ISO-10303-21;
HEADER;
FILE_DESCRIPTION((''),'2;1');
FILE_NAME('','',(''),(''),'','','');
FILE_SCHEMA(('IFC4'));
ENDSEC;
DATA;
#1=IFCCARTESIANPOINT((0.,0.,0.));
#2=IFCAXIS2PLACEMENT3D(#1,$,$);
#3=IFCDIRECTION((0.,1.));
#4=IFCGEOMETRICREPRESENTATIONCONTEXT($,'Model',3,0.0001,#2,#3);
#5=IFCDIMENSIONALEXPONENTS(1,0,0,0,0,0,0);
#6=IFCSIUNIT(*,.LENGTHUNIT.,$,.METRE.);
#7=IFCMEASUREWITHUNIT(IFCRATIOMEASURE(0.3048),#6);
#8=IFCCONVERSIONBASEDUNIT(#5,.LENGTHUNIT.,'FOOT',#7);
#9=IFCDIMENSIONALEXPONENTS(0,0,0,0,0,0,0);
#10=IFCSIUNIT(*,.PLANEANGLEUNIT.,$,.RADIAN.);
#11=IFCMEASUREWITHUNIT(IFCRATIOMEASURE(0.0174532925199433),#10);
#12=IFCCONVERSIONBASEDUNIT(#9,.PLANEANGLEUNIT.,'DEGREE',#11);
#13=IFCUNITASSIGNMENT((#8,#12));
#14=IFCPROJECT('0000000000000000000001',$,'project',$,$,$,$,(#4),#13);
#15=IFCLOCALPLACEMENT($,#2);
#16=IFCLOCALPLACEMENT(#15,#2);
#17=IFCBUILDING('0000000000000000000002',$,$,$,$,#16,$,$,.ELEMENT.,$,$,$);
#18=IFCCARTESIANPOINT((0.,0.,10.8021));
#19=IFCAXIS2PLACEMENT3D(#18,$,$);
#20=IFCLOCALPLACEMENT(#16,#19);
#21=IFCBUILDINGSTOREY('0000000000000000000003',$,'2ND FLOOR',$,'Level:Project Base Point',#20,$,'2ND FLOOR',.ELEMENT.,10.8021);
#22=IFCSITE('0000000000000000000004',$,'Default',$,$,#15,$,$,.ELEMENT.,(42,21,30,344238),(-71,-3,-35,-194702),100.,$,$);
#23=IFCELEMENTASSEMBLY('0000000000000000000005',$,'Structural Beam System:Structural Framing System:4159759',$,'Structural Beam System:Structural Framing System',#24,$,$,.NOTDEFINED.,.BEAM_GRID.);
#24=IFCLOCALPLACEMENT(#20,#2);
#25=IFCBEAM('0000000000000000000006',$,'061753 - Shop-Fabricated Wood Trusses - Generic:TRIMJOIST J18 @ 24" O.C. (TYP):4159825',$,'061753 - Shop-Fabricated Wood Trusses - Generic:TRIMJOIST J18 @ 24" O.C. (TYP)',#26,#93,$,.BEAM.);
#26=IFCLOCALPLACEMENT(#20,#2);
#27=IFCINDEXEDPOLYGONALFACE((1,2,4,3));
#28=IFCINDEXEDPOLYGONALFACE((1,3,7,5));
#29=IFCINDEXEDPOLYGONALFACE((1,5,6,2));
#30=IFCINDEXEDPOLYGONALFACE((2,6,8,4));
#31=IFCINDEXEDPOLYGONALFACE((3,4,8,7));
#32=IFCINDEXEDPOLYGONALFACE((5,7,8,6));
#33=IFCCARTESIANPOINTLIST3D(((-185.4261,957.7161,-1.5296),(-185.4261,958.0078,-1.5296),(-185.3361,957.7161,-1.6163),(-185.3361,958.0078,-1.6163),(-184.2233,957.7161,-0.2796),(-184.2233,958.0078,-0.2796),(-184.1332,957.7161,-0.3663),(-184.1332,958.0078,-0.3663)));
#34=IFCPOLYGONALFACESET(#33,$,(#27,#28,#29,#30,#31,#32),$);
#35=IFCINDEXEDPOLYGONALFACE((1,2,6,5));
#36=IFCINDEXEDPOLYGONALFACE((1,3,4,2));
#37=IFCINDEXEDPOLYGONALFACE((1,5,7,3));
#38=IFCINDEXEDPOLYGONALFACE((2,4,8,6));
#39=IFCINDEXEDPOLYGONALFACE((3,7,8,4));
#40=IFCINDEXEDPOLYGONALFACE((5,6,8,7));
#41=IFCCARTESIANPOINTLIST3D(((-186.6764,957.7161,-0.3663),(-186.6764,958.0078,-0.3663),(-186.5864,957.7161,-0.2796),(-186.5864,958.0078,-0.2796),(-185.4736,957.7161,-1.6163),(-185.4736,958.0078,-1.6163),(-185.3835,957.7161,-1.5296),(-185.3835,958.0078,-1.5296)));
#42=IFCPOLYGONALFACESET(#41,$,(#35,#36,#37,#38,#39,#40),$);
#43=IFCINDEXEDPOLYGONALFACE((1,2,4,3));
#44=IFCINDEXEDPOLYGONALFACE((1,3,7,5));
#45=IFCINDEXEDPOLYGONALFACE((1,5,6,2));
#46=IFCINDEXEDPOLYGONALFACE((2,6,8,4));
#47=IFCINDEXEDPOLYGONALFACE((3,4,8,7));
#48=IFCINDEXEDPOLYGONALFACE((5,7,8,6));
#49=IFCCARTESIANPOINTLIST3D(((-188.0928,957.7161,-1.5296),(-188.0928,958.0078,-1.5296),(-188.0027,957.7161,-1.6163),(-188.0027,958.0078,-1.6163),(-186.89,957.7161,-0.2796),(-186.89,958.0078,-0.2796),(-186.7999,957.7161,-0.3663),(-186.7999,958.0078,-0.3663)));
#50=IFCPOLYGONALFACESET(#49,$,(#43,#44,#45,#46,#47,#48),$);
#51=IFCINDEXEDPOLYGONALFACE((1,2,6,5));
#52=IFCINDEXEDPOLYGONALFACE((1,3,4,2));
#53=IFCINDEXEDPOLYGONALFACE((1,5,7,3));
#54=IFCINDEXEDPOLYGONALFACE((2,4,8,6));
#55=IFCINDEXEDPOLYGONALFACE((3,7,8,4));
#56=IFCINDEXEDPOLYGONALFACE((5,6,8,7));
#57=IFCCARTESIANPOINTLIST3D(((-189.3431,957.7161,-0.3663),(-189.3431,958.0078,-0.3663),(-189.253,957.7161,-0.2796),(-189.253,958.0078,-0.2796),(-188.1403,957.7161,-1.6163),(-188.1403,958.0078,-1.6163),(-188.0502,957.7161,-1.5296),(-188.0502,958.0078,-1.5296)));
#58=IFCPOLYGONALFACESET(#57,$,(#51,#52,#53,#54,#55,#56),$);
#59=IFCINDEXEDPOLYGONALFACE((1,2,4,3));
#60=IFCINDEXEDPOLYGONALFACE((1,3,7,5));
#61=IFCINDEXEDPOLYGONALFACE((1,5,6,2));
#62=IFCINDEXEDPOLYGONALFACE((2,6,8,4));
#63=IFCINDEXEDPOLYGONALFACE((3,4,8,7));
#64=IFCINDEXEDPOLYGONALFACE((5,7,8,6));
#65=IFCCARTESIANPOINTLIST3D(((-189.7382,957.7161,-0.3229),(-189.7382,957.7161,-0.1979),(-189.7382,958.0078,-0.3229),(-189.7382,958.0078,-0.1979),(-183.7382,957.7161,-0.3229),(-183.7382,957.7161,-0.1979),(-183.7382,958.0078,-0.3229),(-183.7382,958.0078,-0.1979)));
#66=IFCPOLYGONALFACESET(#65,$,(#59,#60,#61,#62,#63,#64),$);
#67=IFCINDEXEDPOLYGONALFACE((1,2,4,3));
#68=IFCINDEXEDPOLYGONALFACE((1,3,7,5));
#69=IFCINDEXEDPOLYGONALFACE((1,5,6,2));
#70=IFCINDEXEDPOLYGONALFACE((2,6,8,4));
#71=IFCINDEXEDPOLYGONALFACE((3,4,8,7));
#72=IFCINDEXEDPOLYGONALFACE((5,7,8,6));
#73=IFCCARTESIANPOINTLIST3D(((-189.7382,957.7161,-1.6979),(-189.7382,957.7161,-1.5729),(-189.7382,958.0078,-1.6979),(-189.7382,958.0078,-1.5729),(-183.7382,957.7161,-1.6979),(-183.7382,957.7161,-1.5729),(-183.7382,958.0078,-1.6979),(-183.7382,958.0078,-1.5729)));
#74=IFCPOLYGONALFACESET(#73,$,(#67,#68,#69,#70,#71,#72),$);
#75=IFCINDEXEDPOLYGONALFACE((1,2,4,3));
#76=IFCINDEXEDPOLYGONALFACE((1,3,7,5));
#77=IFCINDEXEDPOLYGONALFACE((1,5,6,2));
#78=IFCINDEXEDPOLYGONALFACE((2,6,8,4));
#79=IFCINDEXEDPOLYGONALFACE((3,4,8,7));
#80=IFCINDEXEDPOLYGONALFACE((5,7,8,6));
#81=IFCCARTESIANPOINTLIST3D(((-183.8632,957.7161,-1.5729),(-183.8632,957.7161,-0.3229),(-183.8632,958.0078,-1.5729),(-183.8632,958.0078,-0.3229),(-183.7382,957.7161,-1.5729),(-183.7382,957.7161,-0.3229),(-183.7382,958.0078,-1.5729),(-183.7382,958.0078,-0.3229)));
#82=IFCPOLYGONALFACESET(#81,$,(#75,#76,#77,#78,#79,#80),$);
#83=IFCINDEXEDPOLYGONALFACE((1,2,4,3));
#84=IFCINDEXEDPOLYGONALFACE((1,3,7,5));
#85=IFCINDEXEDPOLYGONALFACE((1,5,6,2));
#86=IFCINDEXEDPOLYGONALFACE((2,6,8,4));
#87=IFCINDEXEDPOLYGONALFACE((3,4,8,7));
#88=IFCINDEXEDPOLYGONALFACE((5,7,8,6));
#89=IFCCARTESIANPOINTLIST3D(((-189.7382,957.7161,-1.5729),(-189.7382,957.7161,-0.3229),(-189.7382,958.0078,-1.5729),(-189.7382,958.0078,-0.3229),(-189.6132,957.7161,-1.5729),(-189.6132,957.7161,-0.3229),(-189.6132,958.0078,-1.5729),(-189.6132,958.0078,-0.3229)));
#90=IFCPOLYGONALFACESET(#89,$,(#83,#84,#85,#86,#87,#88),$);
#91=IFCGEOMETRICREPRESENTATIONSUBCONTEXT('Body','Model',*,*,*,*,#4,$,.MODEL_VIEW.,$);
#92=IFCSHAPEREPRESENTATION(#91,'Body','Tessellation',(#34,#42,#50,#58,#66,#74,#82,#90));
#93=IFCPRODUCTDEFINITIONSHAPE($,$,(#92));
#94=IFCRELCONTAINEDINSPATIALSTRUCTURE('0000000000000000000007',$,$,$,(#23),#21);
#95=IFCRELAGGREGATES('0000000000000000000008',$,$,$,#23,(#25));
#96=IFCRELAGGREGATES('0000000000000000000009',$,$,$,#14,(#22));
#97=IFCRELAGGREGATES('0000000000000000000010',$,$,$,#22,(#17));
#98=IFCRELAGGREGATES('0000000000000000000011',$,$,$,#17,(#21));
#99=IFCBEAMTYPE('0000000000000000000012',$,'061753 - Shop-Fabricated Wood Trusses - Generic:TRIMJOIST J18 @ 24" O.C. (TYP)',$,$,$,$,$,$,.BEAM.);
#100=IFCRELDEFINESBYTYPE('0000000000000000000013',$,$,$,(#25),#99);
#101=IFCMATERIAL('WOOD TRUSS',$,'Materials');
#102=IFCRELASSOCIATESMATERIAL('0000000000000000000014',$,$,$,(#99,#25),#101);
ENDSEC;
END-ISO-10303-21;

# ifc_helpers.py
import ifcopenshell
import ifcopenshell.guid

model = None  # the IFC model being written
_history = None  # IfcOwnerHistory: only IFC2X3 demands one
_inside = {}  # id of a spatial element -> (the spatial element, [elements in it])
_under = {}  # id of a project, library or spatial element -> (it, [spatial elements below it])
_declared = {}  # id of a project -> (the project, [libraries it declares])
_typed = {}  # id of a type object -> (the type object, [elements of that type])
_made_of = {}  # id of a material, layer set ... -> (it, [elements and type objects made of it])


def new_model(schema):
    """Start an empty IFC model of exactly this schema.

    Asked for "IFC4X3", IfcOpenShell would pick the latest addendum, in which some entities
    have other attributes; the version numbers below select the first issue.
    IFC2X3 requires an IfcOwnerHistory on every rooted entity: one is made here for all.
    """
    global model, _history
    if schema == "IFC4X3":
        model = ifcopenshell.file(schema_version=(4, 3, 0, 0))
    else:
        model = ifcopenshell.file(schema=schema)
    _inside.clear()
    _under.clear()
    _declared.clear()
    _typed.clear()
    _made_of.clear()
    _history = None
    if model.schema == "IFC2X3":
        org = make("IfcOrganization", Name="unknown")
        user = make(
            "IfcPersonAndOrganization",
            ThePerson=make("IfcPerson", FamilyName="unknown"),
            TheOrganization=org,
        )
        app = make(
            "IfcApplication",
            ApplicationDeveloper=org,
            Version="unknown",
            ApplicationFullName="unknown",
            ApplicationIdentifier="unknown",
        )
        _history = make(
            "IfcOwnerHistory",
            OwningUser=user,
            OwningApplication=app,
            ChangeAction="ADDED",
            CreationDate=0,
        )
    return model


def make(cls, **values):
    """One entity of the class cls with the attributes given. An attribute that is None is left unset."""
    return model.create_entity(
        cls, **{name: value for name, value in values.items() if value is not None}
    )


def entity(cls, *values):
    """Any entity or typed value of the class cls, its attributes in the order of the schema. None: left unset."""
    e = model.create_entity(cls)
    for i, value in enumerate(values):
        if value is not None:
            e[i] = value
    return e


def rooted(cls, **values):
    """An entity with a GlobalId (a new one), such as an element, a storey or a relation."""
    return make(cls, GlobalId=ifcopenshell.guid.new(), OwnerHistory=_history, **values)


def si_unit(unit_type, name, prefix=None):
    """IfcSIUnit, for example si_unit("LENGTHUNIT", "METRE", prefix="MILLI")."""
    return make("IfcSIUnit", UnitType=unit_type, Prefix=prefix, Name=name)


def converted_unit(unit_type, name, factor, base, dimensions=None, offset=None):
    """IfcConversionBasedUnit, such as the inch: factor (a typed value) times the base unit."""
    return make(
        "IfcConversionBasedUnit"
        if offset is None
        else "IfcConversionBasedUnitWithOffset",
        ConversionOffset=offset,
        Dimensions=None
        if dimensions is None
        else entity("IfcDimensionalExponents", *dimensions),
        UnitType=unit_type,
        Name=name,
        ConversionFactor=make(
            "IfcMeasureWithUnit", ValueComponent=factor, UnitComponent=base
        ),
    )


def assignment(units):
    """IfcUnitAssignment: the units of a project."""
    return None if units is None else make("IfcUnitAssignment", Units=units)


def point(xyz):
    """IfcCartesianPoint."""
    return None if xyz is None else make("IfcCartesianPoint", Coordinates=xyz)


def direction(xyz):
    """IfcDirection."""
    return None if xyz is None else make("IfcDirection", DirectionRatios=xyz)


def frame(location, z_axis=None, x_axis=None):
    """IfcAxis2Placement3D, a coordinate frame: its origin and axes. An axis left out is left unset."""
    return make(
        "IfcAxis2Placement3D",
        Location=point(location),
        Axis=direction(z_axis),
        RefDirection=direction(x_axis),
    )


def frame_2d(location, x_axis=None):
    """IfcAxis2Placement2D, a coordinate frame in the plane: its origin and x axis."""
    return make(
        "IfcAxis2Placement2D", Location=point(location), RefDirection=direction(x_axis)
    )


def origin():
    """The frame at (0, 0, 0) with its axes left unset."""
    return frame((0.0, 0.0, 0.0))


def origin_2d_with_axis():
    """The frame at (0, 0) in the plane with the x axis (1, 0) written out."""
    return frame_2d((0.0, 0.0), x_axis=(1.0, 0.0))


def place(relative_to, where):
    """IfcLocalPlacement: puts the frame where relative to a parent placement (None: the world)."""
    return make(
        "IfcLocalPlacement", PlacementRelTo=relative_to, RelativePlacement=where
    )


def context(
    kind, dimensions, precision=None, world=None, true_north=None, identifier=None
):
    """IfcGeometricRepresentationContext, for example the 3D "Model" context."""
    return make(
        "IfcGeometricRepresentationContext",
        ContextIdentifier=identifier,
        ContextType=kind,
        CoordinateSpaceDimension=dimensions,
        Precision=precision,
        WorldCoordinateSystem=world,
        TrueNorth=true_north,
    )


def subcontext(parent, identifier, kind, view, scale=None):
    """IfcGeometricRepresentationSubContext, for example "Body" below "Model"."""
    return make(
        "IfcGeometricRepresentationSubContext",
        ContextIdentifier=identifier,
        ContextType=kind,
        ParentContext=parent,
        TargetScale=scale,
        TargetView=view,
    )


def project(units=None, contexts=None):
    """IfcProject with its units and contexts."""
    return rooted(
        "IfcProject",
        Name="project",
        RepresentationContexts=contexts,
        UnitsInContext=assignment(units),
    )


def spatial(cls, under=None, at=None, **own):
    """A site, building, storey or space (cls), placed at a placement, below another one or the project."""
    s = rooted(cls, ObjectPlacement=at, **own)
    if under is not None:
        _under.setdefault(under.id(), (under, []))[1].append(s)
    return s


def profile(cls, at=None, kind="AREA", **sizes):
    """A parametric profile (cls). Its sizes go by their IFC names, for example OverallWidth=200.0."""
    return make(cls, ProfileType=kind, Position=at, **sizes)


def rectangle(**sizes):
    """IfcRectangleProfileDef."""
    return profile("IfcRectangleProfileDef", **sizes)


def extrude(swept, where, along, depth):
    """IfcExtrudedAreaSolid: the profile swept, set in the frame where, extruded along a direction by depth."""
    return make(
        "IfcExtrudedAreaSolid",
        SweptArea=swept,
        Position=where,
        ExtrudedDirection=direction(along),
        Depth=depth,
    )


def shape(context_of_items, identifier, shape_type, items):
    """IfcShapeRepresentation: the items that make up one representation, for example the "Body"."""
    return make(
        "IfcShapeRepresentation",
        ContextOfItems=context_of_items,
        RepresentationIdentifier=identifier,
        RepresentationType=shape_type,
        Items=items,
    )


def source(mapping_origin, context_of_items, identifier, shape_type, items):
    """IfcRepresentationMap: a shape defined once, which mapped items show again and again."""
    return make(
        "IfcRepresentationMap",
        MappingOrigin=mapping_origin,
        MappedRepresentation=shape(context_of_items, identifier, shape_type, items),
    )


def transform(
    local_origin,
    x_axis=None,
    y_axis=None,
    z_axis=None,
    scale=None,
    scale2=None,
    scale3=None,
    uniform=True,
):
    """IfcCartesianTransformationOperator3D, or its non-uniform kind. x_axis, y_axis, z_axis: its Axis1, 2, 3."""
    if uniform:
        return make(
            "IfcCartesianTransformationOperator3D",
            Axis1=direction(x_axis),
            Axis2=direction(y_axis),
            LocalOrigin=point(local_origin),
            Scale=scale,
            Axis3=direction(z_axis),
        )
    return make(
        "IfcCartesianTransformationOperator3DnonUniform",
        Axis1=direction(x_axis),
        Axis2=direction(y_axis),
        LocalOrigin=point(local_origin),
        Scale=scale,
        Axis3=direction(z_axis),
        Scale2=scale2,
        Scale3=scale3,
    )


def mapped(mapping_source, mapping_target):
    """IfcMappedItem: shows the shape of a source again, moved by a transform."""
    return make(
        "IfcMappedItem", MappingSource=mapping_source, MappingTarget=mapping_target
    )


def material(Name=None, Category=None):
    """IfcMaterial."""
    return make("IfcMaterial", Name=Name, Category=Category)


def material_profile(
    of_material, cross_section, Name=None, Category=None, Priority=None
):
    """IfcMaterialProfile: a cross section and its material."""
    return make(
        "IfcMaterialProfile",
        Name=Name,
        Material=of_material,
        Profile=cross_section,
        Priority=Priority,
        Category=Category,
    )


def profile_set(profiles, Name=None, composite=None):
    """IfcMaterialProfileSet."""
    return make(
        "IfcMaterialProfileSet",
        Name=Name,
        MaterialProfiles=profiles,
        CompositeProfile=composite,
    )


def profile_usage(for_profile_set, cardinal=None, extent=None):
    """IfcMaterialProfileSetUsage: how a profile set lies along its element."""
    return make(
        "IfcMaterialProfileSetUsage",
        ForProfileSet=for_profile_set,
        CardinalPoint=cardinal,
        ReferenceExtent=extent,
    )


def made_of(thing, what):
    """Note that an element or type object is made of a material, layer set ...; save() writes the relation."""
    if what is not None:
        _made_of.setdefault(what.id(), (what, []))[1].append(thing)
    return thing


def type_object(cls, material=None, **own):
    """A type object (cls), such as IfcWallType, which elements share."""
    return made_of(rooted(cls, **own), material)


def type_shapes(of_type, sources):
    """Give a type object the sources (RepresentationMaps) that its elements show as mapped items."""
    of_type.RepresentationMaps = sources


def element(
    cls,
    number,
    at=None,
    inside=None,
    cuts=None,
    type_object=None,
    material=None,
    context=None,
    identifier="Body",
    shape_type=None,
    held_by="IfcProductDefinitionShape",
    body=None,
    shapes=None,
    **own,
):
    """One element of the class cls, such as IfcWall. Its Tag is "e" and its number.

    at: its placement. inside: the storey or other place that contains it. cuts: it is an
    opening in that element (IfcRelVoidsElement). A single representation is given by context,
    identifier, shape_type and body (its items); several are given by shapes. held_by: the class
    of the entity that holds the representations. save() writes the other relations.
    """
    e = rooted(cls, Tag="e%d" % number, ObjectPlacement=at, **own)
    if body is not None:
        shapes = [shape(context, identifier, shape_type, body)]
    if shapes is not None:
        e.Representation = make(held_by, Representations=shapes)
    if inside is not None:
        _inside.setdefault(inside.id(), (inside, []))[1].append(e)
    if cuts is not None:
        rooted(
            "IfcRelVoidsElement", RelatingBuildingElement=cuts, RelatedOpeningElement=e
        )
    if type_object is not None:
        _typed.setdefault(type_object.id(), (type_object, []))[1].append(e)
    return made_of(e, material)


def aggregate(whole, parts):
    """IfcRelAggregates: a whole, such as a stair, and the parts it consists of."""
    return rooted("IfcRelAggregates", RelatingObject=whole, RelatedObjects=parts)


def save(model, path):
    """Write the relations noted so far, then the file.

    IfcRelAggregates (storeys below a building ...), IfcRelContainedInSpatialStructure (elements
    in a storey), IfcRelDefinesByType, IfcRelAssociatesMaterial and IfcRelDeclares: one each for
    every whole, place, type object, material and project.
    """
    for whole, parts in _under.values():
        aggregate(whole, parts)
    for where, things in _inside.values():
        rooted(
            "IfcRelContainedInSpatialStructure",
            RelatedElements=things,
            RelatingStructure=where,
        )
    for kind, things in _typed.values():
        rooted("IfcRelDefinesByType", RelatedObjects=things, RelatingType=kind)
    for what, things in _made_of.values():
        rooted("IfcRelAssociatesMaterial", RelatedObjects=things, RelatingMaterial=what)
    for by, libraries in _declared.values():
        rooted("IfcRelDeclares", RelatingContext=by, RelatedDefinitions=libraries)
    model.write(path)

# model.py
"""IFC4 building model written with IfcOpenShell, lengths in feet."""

from ifc_helpers import new_model, entity, si_unit, converted_unit, direction, frame, frame_2d, origin, origin_2d_with_axis, place, context, subcontext, project, spatial, rectangle, extrude, source, transform, mapped, material, material_profile, profile_set, profile_usage, type_object, type_shapes, element, aggregate, save


model = new_model("IFC4")

# Units and contexts
model_context = context("Model", 3, precision=0.0001, world=origin(), true_north=direction((0.0, 1.0)))
body_context = subcontext(model_context, "Body", "Model", "MODEL_VIEW")
ifc_project = project(units=[converted_unit("LENGTHUNIT", "FOOT", entity("IfcRatioMeasure", 0.3048), si_unit("LENGTHUNIT", "METRE"), dimensions=[1, 0, 0, 0, 0, 0, 0]), converted_unit("PLANEANGLEUNIT", "DEGREE", entity("IfcRatioMeasure", 0.0174532925199433), si_unit("PLANEANGLEUNIT", "RADIAN"), dimensions=[0, 0, 0, 0, 0, 0, 0])], contexts=[model_context])

# Site, building, storey
site_placement = place(None, origin())
site = spatial("IfcSite", under=ifc_project, at=site_placement, Name="Default", CompositionType="ELEMENT", RefLatitude=(42, 21, 30, 344238), RefLongitude=(-71, -3, -35, -194702), RefElevation=100.0)
building_placement = place(site_placement, origin())
building = spatial("IfcBuilding", under=site, at=building_placement, CompositionType="ELEMENT")
storey_placement = place(building_placement, frame((0.0, 0.0, 10.8021)))
storey = spatial("IfcBuildingStorey", under=building, at=storey_placement, Name="2ND FLOOR", ObjectType="Level:Project Base Point", LongName="2ND FLOOR", CompositionType="ELEMENT", Elevation=10.8021)

# Element assembly
ifc_material_1 = material(Name="WOOD TRUSS", Category="Materials")
ifc_material_profile_1 = material_profile(ifc_material_1, rectangle(XDim=1.7347, YDim=0.125, at=frame_2d((0.0, 0.0), x_axis=(1.0, 0.0))), Name="TRIMJOIST J18 @ 24\" O.C. (TYP)")
ifc_material_profile_2 = material_profile(ifc_material_1, rectangle(XDim=1.7347, YDim=0.125, at=frame_2d((0.0, 0.0), x_axis=(1.0, 0.0))), Name="TRIMJOIST J18 @ 24\" O.C. (TYP)")
ifc_material_profile_3 = material_profile(ifc_material_1, rectangle(XDim=1.7347, YDim=0.125, at=frame_2d((0.0, 0.0), x_axis=(1.0, 0.0))), Name="TRIMJOIST J18 @ 24\" O.C. (TYP)")
ifc_material_profile_4 = material_profile(ifc_material_1, rectangle(XDim=1.7347, YDim=0.125, at=frame_2d((0.0, 0.0), x_axis=(1.0, 0.0))), Name="TRIMJOIST J18 @ 24\" O.C. (TYP)")
ifc_material_profile_5 = material_profile(ifc_material_1, rectangle(XDim=1.7347, YDim=0.125, at=frame_2d((0.0, 0.0), x_axis=(1.0, 0.0))), Name="TRIMJOIST J18 @ 24\" O.C. (TYP)")
ifc_material_profile_6 = material_profile(ifc_material_1, rectangle(XDim=1.7347, YDim=0.125, at=frame_2d((0.0, 0.0), x_axis=(1.0, 0.0))), Name="TRIMJOIST J18 @ 24\" O.C. (TYP)")
ifc_material_profile_7 = material_profile(ifc_material_1, rectangle(XDim=1.7347, YDim=0.125, at=frame_2d((0.0, 0.0), x_axis=(1.0, 0.0))), Name="TRIMJOIST J18 @ 24\" O.C. (TYP)")
ifc_material_profile_8 = material_profile(ifc_material_1, rectangle(XDim=1.7347, YDim=0.125, at=frame_2d((0.0, 0.0), x_axis=(1.0, 0.0))), Name="TRIMJOIST J18 @ 24\" O.C. (TYP)")
ifc_material_profile_9 = material_profile(ifc_material_1, rectangle(XDim=1.7347, YDim=0.125, at=frame_2d((0.0, 0.0), x_axis=(1.0, 0.0))), Name="TRIMJOIST J18 @ 24\" O.C. (TYP)")
ifc_material_profile_10 = material_profile(ifc_material_1, rectangle(XDim=1.7347, YDim=0.125, at=origin_2d_with_axis()), Name="TRIMJOIST J18 @ 24\" O.C. (TYP)")
ifc_material_profile_11 = material_profile(ifc_material_1, rectangle(XDim=0.125, YDim=0.2917, at=origin_2d_with_axis()), Name="TRIMJOIST J18 @ 24\" O.C. (TYP)")
ifc_material_profile_12 = material_profile(ifc_material_1, rectangle(XDim=0.125, YDim=0.2917, at=origin_2d_with_axis()), Name="TRIMJOIST J18 @ 24\" O.C. (TYP)")
ifc_material_profile_13 = material_profile(ifc_material_1, rectangle(XDim=1.25, YDim=0.2917, at=origin_2d_with_axis()), Name="TRIMJOIST J18 @ 24\" O.C. (TYP)")
ifc_material_profile_14 = material_profile(ifc_material_1, rectangle(XDim=1.25, YDim=0.2917, at=origin_2d_with_axis()), Name="TRIMJOIST J18 @ 24\" O.C. (TYP)")
ifc_profile_set_1 = profile_set([ifc_material_profile_1, ifc_material_profile_2, ifc_material_profile_3, ifc_material_profile_4, ifc_material_profile_5, ifc_material_profile_6, ifc_material_profile_7, ifc_material_profile_8, ifc_material_profile_9, ifc_material_profile_10, ifc_material_profile_11, ifc_material_profile_12, ifc_material_profile_13, ifc_material_profile_14], Name="TRIMJOIST J18 @ 24\" O.C. (TYP)")
assembly_1_placement = place(storey_placement, origin())
assembly_1 = element("IfcElementAssembly", 1, at=assembly_1_placement, inside=storey, Name="Structural Beam System:Structural Framing System:4159759", ObjectType="Structural Beam System:Structural Framing System", AssemblyPlace="NOTDEFINED", PredefinedType="BEAM_GRID")

# Beam
ifc_profile_usage_1 = profile_usage(ifc_profile_set_1, cardinal=8)
beam_type_1 = type_object("IfcBeamType", Name="061753 - Shop-Fabricated Wood Trusses - Generic:TRIMJOIST J18 @ 24\" O.C. (TYP)", PredefinedType="BEAM", material=ifc_profile_set_1)
shared_shape_1 = source(origin(), body_context, "Body", "SweptSolid", [
    extrude(rectangle(XDim=1.7347, YDim=0.125, at=frame_2d((0.0, 0.0), x_axis=(1.0, 0.0))), frame((1.9585, -0.1458, 0.0), z_axis=(0.0, 1.0, 0.0), x_axis=(0.693383, 0.0, 0.720569)), (0.0, 0.0, 1.0), 0.2917),
    extrude(rectangle(XDim=1.7347, YDim=0.125, at=frame_2d((0.0, 0.0), x_axis=(1.0, 0.0))), frame((0.7082, -0.1458, 0.0), z_axis=(0.0, 1.0, 0.0), x_axis=(0.693383, 0.0, -0.720569)), (0.0, 0.0, 1.0), 0.2917),
    extrude(rectangle(XDim=1.7347, YDim=0.125, at=frame_2d((0.0, 0.0), x_axis=(1.0, 0.0))), frame((-0.7082, -0.1458, 0.0), z_axis=(0.0, 1.0, 0.0), x_axis=(0.693383, 0.0, 0.720569)), (0.0, 0.0, 1.0), 0.2917),
    extrude(rectangle(XDim=1.7347, YDim=0.125, at=frame_2d((0.0, 0.0), x_axis=(1.0, 0.0))), frame((-1.9585, -0.1458, 0.0), z_axis=(0.0, 1.0, 0.0), x_axis=(0.693383, 0.0, -0.720569)), (0.0, 0.0, 1.0), 0.2917),
    extrude(rectangle(XDim=0.125, YDim=0.2917, at=origin_2d_with_axis()), frame((-3.0, 0.0, 0.6875), z_axis=(1.0, 0.0, 0.0), x_axis=(0.0, 0.0, -1.0)), (0.0, 0.0, 1.0), 6.0),
    extrude(rectangle(XDim=0.125, YDim=0.2917, at=origin_2d_with_axis()), frame((-3.0, 0.0, -0.6875), z_axis=(1.0, 0.0, 0.0), x_axis=(0.0, 0.0, -1.0)), (0.0, 0.0, 1.0), 6.0),
    extrude(rectangle(XDim=1.25, YDim=0.2917, at=origin_2d_with_axis()), frame((2.875, 0.0, 0.0), z_axis=(1.0, 0.0, 0.0), x_axis=(0.0, 0.0, -1.0)), (0.0, 0.0, 1.0), 0.125),
    extrude(rectangle(XDim=1.25, YDim=0.2917, at=origin_2d_with_axis()), frame((-3.0, 0.0, 0.0), z_axis=(1.0, 0.0, 0.0), x_axis=(0.0, 0.0, -1.0)), (0.0, 0.0, 1.0), 0.125),
])
type_shapes(beam_type_1, [shared_shape_1])
beam_1_placement = place(assembly_1_placement, frame((-186.7382, 957.8619, -0.9479)))
beam_1 = element("IfcBeam", 2, at=beam_1_placement, type_object=beam_type_1, material=ifc_profile_usage_1, Name="061753 - Shop-Fabricated Wood Trusses - Generic:TRIMJOIST J18 @ 24\" O.C. (TYP):4159825", ObjectType="061753 - Shop-Fabricated Wood Trusses - Generic:TRIMJOIST J18 @ 24\" O.C. (TYP)", PredefinedType="BEAM", context=body_context, shape_type="MappedRepresentation", body=[
    mapped(shared_shape_1, transform((0.0, 0.0, 0.0), scale=1.0)),
])
aggregate(assembly_1, [beam_1])

save(model, "model.ifc")
